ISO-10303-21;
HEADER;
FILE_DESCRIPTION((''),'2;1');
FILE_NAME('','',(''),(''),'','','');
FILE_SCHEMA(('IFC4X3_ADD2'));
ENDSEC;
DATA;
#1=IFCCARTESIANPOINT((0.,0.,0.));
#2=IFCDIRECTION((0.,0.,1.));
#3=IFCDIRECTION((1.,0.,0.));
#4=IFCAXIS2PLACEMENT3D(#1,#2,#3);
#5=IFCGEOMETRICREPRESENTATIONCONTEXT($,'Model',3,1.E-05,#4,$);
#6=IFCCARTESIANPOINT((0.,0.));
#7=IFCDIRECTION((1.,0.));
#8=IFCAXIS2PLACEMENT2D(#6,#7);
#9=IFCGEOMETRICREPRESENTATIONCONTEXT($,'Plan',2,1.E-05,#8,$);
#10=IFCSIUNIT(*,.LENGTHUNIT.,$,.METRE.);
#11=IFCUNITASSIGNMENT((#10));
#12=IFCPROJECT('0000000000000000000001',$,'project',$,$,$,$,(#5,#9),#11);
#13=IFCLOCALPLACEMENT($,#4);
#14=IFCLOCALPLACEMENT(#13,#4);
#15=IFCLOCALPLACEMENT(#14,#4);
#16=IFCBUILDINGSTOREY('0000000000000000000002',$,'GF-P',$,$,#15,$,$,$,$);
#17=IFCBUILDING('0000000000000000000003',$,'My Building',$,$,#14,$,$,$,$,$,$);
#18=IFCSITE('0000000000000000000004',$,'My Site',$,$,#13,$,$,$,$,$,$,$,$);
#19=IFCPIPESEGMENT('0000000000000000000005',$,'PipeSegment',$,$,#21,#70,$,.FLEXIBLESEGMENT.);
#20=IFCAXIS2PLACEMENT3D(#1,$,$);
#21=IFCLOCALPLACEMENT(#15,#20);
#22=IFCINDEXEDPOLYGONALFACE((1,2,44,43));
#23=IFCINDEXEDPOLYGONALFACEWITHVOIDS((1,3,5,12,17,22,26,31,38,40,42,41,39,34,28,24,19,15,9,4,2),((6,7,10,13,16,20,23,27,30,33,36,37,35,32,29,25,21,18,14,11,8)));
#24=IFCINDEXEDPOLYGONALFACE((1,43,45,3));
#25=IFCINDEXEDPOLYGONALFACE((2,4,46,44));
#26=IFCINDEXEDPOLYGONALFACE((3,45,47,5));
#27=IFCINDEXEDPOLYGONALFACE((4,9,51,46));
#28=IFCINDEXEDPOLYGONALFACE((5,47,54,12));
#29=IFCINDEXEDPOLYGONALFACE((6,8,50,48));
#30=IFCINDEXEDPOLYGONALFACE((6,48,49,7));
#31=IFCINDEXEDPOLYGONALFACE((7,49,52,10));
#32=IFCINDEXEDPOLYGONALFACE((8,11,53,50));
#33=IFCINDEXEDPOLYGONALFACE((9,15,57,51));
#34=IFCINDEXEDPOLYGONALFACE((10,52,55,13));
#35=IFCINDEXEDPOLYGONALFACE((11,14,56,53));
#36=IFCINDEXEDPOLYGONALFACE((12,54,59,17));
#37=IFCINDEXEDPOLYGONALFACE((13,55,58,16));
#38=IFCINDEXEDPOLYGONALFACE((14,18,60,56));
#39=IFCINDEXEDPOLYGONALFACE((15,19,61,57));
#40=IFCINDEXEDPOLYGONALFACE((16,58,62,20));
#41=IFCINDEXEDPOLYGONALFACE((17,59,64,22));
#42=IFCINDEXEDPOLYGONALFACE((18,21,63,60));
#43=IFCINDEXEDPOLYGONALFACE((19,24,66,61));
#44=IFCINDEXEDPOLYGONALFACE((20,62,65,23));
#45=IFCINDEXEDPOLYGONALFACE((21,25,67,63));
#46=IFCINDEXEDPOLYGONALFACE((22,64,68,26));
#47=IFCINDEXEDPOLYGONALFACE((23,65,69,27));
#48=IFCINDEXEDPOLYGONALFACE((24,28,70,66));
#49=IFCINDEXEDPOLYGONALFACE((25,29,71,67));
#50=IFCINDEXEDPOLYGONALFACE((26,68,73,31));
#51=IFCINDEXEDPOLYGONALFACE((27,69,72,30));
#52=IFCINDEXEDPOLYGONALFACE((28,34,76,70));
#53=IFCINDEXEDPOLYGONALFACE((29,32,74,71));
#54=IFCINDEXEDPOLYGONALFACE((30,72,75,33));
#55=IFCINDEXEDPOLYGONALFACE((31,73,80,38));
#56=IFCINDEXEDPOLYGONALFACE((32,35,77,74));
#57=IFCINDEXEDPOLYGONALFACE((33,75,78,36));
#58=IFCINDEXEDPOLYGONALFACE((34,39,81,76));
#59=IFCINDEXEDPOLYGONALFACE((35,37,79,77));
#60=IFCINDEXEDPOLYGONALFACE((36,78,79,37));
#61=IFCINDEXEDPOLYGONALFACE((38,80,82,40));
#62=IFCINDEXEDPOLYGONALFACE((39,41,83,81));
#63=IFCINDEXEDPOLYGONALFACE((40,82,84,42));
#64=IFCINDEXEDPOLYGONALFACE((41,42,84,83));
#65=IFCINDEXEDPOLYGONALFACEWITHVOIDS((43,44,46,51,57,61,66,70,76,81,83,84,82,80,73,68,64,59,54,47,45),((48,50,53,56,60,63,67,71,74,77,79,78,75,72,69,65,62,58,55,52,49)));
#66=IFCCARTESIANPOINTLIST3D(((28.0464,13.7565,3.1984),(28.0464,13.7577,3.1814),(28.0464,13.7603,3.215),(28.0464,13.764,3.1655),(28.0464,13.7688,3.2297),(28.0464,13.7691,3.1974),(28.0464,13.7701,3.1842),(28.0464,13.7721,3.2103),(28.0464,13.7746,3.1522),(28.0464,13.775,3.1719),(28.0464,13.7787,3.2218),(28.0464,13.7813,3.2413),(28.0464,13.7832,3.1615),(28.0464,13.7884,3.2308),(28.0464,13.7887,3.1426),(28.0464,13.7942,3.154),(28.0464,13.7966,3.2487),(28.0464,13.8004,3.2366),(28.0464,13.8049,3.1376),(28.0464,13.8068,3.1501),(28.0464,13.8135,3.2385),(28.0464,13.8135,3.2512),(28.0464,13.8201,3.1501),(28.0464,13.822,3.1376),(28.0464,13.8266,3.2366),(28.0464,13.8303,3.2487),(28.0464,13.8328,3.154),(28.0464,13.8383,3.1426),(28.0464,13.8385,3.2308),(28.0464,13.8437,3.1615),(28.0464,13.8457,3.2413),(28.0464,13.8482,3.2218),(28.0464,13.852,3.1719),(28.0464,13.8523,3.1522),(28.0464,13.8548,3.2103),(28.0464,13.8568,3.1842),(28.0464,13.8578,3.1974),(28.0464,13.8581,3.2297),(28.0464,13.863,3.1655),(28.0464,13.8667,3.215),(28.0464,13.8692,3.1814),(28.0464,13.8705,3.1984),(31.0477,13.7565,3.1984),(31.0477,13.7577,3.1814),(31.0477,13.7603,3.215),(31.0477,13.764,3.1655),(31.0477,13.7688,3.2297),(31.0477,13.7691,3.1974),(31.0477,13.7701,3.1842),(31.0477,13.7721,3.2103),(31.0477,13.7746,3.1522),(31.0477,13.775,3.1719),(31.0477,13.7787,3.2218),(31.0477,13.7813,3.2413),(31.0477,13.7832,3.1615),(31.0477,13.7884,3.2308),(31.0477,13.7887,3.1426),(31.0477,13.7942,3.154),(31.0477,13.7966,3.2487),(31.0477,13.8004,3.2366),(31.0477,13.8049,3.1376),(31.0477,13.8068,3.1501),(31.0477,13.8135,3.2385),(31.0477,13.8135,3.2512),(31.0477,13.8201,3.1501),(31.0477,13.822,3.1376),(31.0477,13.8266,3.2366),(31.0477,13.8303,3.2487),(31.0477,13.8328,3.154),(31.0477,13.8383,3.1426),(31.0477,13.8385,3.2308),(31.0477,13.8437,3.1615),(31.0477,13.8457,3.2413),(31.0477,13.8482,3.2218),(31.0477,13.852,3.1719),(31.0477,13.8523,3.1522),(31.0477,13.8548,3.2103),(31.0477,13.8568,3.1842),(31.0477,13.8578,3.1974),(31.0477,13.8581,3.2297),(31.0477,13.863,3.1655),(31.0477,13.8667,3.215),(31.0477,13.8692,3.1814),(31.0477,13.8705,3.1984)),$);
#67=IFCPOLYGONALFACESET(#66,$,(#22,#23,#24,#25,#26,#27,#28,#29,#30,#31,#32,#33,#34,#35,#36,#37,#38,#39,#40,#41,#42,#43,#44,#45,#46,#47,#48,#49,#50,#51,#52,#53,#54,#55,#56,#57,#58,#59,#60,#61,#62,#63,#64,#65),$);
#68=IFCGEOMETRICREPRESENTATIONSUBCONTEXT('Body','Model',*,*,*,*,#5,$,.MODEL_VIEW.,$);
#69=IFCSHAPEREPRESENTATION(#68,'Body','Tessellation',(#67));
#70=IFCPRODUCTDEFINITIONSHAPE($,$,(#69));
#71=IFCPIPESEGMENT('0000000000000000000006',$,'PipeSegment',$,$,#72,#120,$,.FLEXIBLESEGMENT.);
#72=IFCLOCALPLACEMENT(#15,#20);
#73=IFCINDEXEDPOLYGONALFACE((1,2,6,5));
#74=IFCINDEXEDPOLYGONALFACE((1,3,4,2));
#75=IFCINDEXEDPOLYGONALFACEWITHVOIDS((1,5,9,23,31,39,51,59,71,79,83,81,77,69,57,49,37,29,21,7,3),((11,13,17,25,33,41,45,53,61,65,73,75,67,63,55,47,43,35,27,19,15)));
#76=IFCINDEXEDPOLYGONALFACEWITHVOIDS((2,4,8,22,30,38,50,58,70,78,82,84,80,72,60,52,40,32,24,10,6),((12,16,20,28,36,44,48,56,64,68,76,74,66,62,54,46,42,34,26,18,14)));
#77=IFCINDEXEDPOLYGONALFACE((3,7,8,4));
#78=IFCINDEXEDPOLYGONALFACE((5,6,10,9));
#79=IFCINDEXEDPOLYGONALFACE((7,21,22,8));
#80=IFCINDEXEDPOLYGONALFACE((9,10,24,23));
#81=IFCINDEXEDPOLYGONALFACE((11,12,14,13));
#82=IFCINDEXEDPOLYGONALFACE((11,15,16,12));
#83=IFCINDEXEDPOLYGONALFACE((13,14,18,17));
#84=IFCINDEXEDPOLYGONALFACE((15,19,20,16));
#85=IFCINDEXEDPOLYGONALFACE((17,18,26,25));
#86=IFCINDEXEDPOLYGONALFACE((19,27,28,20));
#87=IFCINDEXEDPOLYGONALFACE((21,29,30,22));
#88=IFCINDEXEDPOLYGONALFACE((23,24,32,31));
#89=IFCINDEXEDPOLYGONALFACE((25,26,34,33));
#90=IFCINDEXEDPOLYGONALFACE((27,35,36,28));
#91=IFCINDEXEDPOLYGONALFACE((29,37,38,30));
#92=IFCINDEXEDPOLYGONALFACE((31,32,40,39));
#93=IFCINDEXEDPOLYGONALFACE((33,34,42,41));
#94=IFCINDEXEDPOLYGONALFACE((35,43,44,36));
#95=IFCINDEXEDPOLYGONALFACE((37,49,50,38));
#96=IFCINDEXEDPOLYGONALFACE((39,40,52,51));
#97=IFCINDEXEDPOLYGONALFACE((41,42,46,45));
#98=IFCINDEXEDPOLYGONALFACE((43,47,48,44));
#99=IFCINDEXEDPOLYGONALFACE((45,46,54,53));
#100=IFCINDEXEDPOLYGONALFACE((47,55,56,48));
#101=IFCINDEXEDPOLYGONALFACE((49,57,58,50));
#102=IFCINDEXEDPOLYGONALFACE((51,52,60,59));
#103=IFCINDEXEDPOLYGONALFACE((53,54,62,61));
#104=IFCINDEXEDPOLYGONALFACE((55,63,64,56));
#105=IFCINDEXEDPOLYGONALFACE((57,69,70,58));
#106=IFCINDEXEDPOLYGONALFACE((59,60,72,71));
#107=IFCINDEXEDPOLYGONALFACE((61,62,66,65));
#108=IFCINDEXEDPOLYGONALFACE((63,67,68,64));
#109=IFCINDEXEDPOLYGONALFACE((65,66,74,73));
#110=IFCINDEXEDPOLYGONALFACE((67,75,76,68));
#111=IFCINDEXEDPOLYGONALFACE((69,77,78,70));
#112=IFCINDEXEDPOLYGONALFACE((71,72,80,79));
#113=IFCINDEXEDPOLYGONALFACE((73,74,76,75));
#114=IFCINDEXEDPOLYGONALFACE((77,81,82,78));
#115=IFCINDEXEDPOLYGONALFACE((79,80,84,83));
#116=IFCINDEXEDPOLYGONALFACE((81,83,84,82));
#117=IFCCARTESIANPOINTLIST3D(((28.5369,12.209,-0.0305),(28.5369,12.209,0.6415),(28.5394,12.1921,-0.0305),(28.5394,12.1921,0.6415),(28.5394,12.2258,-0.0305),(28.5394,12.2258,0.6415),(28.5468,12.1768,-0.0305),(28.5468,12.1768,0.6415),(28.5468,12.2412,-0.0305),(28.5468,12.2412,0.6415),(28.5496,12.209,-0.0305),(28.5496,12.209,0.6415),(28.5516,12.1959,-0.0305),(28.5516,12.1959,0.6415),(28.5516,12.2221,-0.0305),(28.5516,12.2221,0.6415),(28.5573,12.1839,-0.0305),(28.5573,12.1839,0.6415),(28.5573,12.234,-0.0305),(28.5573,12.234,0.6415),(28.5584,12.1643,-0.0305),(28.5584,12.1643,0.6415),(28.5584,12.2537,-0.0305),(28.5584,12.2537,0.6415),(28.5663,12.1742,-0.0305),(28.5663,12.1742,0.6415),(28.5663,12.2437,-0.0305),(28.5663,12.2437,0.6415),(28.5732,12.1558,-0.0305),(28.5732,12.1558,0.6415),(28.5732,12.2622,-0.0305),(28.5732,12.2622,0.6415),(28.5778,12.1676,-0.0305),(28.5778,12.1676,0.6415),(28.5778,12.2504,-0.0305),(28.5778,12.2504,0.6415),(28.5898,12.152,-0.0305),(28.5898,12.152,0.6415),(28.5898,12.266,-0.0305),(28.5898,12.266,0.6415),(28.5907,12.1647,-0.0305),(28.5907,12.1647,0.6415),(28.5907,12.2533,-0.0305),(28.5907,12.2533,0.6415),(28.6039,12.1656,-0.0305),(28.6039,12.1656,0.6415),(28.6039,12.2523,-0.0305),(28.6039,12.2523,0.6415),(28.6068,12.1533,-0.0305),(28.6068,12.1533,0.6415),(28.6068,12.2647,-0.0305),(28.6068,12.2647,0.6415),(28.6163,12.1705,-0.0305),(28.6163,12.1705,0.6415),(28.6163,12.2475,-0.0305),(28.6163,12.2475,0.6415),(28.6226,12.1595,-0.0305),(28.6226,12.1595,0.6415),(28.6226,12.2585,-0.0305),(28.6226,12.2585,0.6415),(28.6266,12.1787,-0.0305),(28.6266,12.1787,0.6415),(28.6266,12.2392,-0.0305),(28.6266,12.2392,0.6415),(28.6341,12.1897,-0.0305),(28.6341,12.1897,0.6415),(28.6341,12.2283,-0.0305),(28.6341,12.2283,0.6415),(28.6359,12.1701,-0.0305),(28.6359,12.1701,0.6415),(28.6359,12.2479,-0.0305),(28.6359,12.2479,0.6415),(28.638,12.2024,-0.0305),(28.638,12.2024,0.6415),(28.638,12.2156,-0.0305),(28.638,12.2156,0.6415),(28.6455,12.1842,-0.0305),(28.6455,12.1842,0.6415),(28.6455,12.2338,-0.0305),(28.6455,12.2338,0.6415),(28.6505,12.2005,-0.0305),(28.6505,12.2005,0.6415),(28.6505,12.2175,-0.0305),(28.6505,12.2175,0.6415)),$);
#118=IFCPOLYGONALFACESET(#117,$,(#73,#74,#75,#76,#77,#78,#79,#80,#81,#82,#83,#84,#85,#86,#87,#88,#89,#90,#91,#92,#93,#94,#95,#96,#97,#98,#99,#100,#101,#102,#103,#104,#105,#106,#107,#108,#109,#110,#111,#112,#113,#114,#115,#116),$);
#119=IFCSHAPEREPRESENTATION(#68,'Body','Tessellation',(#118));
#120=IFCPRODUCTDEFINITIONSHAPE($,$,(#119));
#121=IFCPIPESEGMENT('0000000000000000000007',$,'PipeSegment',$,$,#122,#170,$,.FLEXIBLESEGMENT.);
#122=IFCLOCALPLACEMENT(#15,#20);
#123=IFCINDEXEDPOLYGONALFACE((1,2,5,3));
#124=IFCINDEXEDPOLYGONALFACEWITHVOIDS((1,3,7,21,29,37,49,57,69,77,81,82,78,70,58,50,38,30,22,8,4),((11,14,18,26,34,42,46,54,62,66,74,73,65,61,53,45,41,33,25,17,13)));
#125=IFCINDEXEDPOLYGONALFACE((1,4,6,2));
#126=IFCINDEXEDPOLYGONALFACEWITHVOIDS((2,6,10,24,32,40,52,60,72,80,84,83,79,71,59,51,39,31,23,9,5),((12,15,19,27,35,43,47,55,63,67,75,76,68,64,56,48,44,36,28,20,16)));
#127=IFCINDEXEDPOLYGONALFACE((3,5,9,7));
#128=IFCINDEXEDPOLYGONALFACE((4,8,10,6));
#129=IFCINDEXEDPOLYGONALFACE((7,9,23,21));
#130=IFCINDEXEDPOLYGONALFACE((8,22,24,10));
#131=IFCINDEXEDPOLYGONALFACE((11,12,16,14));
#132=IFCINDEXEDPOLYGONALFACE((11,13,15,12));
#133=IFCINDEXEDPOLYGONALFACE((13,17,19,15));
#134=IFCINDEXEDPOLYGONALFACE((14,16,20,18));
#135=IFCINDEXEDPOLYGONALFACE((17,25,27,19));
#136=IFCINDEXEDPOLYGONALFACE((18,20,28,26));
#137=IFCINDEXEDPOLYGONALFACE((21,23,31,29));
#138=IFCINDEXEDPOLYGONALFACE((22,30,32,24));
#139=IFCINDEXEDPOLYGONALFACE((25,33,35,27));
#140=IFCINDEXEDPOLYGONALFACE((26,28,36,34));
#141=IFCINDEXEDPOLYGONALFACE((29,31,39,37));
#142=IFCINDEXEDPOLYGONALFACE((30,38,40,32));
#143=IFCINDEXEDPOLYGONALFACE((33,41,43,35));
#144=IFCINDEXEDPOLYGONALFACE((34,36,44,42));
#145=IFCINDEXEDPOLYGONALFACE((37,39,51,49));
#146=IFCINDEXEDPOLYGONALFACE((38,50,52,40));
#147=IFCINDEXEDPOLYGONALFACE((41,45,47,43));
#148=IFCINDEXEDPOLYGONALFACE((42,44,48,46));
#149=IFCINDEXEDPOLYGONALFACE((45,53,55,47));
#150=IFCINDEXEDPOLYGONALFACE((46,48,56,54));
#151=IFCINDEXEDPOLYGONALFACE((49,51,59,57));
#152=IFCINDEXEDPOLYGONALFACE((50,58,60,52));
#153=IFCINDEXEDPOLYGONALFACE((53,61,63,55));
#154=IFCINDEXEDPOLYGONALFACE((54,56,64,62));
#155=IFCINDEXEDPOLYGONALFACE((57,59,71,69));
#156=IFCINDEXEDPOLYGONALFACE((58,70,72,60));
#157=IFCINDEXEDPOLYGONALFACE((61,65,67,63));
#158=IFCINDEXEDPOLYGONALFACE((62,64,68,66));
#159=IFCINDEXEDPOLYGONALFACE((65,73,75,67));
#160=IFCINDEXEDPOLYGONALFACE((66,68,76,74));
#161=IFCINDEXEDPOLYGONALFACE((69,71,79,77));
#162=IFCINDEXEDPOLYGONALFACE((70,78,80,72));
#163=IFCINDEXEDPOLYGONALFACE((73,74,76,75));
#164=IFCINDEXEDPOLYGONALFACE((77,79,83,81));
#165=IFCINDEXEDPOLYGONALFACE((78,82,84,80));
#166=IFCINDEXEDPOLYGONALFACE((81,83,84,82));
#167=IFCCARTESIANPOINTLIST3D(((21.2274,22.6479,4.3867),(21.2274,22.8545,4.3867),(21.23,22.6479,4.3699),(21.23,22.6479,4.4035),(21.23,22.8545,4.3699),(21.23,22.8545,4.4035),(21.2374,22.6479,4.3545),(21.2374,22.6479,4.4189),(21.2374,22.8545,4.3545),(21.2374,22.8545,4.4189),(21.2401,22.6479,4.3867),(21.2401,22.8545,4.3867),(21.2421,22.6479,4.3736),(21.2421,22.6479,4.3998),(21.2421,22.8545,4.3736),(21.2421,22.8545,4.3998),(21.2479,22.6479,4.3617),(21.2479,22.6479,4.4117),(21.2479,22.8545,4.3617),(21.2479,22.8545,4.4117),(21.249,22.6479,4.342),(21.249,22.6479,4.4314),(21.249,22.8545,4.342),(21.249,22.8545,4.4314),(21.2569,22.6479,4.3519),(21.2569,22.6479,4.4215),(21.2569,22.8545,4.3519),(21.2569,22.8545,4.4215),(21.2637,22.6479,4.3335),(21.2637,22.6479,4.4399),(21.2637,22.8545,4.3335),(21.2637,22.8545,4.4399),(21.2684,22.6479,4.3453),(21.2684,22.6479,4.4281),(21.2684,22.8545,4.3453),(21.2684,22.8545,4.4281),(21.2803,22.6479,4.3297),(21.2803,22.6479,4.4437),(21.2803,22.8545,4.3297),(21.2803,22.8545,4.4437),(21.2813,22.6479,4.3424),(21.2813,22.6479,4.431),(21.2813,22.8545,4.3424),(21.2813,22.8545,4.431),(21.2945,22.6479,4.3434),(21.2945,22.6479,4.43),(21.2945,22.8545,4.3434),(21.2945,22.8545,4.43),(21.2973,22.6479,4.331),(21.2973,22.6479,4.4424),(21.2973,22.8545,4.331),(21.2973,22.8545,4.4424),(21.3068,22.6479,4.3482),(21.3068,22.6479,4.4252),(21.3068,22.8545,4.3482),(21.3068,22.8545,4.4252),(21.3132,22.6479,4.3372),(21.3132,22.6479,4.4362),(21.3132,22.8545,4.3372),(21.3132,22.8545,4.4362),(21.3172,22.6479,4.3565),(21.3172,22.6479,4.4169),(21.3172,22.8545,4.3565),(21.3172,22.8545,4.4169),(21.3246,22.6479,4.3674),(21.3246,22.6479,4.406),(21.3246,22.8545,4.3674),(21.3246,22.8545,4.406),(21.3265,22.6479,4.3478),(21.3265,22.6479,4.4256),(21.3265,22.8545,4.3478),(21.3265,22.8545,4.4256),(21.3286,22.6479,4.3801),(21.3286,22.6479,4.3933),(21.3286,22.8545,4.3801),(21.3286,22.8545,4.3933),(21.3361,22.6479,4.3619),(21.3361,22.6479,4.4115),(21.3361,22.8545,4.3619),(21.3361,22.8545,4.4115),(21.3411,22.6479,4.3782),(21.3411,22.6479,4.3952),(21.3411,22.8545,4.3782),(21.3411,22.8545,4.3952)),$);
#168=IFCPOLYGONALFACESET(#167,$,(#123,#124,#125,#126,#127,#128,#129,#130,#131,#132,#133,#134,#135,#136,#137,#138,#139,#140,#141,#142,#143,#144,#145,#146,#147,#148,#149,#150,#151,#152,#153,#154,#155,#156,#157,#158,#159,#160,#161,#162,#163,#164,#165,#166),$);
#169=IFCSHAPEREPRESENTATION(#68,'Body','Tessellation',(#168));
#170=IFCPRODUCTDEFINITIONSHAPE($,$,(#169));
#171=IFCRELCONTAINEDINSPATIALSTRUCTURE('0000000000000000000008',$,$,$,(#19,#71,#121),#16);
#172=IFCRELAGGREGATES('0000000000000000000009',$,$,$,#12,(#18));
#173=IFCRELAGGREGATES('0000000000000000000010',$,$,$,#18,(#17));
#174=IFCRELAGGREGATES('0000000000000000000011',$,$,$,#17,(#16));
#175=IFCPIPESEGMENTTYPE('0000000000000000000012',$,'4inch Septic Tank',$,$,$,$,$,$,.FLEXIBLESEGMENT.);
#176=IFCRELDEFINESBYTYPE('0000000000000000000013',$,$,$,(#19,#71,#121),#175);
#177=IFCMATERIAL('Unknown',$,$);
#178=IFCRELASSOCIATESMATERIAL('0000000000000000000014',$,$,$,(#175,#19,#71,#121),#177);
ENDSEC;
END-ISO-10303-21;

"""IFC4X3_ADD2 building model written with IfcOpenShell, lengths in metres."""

from ifc_helpers import new_model, si_unit, frame, origin_with_axes, origin_2d_with_axis, place, context, subcontext, project, spatial, hollow_circle, extrude, material, material_profile, profile_set, profile_usage, type_object, element, save


model = new_model("IFC4X3_ADD2")

# Units and contexts
model_context = context("Model", 3, precision=1e-05, world=origin_with_axes())
plan_context = context("Plan", 2, precision=1e-05, world=origin_2d_with_axis())
body_context = subcontext(model_context, "Body", "Model", "MODEL_VIEW")
ifc_project = project(units=[si_unit("LENGTHUNIT", "METRE")], contexts=[model_context, plan_context])

# Site, building, storey
site_placement = place(None, origin_with_axes())
site = spatial("IfcSite", under=ifc_project, at=site_placement, Name="My Site")
building_placement = place(site_placement, origin_with_axes())
building = spatial("IfcBuilding", under=site, at=building_placement, Name="My Building")
storey_placement = place(building_placement, origin_with_axes())
storey = spatial("IfcBuildingStorey", under=building, at=storey_placement, Name="GF-P")

# Pipe segments
ifc_material_1 = material(Name="Unknown")
ifc_material_profile_1 = material_profile(ifc_material_1, hollow_circle(Radius=0.0571, WallThickness=0.0127))
ifc_profile_set_1 = profile_set([ifc_material_profile_1], Name="blackwater")
pipe_segment_type_1 = type_object("IfcPipeSegmentType", Name="4inch Septic Tank", PredefinedType="FLEXIBLESEGMENT", material=ifc_profile_set_1)
ifc_profile_usage_1 = profile_usage(ifc_profile_set_1, cardinal=5)
pipe_segment_1_placement = place(storey_placement, frame((28.0464, 13.8135, 3.1941), z_axis=(1.0, 0.0, -0.000001), x_axis=(0.000001, 0.0, 1.0)))
element("IfcPipeSegment", 1, at=pipe_segment_1_placement, inside=storey, type_object=pipe_segment_type_1, material=ifc_profile_usage_1, Name="PipeSegment", PredefinedType="FLEXIBLESEGMENT", context=body_context, shape_type="SweptSolid", body=[
    extrude(hollow_circle(Radius=0.0571, WallThickness=0.0127), origin_with_axes(), (0.0, 0.0, 1.0), 3.0013),
])
ifc_profile_usage_2 = profile_usage(ifc_profile_set_1, cardinal=5)
pipe_segment_2_placement = place(storey_placement, frame((28.594, 12.209, -0.0305), z_axis=(0.0, 0.0, 1.0), x_axis=(-1.0, 0.0, 0.0)))
element("IfcPipeSegment", 2, at=pipe_segment_2_placement, inside=storey, type_object=pipe_segment_type_1, material=ifc_profile_usage_2, Name="PipeSegment", PredefinedType="FLEXIBLESEGMENT", context=body_context, shape_type="SweptSolid", body=[
    extrude(hollow_circle(Radius=0.0571, WallThickness=0.0127), origin_with_axes(), (0.0, 0.0, 1.0), 0.6719),
])
ifc_profile_usage_3 = profile_usage(ifc_profile_set_1, cardinal=5)
pipe_segment_3_placement = place(storey_placement, frame((21.2846, 22.6479, 4.3867), z_axis=(0.0, 1.0, 0.0), x_axis=(-1.0, 0.0, 0.0)))
element("IfcPipeSegment", 3, at=pipe_segment_3_placement, inside=storey, type_object=pipe_segment_type_1, material=ifc_profile_usage_3, Name="PipeSegment", PredefinedType="FLEXIBLESEGMENT", context=body_context, shape_type="SweptSolid", body=[
    extrude(hollow_circle(Radius=0.0571, WallThickness=0.0127), origin_with_axes(), (0.0, 0.0, 1.0), 0.2066),
])

save(model, "model.ifc")
